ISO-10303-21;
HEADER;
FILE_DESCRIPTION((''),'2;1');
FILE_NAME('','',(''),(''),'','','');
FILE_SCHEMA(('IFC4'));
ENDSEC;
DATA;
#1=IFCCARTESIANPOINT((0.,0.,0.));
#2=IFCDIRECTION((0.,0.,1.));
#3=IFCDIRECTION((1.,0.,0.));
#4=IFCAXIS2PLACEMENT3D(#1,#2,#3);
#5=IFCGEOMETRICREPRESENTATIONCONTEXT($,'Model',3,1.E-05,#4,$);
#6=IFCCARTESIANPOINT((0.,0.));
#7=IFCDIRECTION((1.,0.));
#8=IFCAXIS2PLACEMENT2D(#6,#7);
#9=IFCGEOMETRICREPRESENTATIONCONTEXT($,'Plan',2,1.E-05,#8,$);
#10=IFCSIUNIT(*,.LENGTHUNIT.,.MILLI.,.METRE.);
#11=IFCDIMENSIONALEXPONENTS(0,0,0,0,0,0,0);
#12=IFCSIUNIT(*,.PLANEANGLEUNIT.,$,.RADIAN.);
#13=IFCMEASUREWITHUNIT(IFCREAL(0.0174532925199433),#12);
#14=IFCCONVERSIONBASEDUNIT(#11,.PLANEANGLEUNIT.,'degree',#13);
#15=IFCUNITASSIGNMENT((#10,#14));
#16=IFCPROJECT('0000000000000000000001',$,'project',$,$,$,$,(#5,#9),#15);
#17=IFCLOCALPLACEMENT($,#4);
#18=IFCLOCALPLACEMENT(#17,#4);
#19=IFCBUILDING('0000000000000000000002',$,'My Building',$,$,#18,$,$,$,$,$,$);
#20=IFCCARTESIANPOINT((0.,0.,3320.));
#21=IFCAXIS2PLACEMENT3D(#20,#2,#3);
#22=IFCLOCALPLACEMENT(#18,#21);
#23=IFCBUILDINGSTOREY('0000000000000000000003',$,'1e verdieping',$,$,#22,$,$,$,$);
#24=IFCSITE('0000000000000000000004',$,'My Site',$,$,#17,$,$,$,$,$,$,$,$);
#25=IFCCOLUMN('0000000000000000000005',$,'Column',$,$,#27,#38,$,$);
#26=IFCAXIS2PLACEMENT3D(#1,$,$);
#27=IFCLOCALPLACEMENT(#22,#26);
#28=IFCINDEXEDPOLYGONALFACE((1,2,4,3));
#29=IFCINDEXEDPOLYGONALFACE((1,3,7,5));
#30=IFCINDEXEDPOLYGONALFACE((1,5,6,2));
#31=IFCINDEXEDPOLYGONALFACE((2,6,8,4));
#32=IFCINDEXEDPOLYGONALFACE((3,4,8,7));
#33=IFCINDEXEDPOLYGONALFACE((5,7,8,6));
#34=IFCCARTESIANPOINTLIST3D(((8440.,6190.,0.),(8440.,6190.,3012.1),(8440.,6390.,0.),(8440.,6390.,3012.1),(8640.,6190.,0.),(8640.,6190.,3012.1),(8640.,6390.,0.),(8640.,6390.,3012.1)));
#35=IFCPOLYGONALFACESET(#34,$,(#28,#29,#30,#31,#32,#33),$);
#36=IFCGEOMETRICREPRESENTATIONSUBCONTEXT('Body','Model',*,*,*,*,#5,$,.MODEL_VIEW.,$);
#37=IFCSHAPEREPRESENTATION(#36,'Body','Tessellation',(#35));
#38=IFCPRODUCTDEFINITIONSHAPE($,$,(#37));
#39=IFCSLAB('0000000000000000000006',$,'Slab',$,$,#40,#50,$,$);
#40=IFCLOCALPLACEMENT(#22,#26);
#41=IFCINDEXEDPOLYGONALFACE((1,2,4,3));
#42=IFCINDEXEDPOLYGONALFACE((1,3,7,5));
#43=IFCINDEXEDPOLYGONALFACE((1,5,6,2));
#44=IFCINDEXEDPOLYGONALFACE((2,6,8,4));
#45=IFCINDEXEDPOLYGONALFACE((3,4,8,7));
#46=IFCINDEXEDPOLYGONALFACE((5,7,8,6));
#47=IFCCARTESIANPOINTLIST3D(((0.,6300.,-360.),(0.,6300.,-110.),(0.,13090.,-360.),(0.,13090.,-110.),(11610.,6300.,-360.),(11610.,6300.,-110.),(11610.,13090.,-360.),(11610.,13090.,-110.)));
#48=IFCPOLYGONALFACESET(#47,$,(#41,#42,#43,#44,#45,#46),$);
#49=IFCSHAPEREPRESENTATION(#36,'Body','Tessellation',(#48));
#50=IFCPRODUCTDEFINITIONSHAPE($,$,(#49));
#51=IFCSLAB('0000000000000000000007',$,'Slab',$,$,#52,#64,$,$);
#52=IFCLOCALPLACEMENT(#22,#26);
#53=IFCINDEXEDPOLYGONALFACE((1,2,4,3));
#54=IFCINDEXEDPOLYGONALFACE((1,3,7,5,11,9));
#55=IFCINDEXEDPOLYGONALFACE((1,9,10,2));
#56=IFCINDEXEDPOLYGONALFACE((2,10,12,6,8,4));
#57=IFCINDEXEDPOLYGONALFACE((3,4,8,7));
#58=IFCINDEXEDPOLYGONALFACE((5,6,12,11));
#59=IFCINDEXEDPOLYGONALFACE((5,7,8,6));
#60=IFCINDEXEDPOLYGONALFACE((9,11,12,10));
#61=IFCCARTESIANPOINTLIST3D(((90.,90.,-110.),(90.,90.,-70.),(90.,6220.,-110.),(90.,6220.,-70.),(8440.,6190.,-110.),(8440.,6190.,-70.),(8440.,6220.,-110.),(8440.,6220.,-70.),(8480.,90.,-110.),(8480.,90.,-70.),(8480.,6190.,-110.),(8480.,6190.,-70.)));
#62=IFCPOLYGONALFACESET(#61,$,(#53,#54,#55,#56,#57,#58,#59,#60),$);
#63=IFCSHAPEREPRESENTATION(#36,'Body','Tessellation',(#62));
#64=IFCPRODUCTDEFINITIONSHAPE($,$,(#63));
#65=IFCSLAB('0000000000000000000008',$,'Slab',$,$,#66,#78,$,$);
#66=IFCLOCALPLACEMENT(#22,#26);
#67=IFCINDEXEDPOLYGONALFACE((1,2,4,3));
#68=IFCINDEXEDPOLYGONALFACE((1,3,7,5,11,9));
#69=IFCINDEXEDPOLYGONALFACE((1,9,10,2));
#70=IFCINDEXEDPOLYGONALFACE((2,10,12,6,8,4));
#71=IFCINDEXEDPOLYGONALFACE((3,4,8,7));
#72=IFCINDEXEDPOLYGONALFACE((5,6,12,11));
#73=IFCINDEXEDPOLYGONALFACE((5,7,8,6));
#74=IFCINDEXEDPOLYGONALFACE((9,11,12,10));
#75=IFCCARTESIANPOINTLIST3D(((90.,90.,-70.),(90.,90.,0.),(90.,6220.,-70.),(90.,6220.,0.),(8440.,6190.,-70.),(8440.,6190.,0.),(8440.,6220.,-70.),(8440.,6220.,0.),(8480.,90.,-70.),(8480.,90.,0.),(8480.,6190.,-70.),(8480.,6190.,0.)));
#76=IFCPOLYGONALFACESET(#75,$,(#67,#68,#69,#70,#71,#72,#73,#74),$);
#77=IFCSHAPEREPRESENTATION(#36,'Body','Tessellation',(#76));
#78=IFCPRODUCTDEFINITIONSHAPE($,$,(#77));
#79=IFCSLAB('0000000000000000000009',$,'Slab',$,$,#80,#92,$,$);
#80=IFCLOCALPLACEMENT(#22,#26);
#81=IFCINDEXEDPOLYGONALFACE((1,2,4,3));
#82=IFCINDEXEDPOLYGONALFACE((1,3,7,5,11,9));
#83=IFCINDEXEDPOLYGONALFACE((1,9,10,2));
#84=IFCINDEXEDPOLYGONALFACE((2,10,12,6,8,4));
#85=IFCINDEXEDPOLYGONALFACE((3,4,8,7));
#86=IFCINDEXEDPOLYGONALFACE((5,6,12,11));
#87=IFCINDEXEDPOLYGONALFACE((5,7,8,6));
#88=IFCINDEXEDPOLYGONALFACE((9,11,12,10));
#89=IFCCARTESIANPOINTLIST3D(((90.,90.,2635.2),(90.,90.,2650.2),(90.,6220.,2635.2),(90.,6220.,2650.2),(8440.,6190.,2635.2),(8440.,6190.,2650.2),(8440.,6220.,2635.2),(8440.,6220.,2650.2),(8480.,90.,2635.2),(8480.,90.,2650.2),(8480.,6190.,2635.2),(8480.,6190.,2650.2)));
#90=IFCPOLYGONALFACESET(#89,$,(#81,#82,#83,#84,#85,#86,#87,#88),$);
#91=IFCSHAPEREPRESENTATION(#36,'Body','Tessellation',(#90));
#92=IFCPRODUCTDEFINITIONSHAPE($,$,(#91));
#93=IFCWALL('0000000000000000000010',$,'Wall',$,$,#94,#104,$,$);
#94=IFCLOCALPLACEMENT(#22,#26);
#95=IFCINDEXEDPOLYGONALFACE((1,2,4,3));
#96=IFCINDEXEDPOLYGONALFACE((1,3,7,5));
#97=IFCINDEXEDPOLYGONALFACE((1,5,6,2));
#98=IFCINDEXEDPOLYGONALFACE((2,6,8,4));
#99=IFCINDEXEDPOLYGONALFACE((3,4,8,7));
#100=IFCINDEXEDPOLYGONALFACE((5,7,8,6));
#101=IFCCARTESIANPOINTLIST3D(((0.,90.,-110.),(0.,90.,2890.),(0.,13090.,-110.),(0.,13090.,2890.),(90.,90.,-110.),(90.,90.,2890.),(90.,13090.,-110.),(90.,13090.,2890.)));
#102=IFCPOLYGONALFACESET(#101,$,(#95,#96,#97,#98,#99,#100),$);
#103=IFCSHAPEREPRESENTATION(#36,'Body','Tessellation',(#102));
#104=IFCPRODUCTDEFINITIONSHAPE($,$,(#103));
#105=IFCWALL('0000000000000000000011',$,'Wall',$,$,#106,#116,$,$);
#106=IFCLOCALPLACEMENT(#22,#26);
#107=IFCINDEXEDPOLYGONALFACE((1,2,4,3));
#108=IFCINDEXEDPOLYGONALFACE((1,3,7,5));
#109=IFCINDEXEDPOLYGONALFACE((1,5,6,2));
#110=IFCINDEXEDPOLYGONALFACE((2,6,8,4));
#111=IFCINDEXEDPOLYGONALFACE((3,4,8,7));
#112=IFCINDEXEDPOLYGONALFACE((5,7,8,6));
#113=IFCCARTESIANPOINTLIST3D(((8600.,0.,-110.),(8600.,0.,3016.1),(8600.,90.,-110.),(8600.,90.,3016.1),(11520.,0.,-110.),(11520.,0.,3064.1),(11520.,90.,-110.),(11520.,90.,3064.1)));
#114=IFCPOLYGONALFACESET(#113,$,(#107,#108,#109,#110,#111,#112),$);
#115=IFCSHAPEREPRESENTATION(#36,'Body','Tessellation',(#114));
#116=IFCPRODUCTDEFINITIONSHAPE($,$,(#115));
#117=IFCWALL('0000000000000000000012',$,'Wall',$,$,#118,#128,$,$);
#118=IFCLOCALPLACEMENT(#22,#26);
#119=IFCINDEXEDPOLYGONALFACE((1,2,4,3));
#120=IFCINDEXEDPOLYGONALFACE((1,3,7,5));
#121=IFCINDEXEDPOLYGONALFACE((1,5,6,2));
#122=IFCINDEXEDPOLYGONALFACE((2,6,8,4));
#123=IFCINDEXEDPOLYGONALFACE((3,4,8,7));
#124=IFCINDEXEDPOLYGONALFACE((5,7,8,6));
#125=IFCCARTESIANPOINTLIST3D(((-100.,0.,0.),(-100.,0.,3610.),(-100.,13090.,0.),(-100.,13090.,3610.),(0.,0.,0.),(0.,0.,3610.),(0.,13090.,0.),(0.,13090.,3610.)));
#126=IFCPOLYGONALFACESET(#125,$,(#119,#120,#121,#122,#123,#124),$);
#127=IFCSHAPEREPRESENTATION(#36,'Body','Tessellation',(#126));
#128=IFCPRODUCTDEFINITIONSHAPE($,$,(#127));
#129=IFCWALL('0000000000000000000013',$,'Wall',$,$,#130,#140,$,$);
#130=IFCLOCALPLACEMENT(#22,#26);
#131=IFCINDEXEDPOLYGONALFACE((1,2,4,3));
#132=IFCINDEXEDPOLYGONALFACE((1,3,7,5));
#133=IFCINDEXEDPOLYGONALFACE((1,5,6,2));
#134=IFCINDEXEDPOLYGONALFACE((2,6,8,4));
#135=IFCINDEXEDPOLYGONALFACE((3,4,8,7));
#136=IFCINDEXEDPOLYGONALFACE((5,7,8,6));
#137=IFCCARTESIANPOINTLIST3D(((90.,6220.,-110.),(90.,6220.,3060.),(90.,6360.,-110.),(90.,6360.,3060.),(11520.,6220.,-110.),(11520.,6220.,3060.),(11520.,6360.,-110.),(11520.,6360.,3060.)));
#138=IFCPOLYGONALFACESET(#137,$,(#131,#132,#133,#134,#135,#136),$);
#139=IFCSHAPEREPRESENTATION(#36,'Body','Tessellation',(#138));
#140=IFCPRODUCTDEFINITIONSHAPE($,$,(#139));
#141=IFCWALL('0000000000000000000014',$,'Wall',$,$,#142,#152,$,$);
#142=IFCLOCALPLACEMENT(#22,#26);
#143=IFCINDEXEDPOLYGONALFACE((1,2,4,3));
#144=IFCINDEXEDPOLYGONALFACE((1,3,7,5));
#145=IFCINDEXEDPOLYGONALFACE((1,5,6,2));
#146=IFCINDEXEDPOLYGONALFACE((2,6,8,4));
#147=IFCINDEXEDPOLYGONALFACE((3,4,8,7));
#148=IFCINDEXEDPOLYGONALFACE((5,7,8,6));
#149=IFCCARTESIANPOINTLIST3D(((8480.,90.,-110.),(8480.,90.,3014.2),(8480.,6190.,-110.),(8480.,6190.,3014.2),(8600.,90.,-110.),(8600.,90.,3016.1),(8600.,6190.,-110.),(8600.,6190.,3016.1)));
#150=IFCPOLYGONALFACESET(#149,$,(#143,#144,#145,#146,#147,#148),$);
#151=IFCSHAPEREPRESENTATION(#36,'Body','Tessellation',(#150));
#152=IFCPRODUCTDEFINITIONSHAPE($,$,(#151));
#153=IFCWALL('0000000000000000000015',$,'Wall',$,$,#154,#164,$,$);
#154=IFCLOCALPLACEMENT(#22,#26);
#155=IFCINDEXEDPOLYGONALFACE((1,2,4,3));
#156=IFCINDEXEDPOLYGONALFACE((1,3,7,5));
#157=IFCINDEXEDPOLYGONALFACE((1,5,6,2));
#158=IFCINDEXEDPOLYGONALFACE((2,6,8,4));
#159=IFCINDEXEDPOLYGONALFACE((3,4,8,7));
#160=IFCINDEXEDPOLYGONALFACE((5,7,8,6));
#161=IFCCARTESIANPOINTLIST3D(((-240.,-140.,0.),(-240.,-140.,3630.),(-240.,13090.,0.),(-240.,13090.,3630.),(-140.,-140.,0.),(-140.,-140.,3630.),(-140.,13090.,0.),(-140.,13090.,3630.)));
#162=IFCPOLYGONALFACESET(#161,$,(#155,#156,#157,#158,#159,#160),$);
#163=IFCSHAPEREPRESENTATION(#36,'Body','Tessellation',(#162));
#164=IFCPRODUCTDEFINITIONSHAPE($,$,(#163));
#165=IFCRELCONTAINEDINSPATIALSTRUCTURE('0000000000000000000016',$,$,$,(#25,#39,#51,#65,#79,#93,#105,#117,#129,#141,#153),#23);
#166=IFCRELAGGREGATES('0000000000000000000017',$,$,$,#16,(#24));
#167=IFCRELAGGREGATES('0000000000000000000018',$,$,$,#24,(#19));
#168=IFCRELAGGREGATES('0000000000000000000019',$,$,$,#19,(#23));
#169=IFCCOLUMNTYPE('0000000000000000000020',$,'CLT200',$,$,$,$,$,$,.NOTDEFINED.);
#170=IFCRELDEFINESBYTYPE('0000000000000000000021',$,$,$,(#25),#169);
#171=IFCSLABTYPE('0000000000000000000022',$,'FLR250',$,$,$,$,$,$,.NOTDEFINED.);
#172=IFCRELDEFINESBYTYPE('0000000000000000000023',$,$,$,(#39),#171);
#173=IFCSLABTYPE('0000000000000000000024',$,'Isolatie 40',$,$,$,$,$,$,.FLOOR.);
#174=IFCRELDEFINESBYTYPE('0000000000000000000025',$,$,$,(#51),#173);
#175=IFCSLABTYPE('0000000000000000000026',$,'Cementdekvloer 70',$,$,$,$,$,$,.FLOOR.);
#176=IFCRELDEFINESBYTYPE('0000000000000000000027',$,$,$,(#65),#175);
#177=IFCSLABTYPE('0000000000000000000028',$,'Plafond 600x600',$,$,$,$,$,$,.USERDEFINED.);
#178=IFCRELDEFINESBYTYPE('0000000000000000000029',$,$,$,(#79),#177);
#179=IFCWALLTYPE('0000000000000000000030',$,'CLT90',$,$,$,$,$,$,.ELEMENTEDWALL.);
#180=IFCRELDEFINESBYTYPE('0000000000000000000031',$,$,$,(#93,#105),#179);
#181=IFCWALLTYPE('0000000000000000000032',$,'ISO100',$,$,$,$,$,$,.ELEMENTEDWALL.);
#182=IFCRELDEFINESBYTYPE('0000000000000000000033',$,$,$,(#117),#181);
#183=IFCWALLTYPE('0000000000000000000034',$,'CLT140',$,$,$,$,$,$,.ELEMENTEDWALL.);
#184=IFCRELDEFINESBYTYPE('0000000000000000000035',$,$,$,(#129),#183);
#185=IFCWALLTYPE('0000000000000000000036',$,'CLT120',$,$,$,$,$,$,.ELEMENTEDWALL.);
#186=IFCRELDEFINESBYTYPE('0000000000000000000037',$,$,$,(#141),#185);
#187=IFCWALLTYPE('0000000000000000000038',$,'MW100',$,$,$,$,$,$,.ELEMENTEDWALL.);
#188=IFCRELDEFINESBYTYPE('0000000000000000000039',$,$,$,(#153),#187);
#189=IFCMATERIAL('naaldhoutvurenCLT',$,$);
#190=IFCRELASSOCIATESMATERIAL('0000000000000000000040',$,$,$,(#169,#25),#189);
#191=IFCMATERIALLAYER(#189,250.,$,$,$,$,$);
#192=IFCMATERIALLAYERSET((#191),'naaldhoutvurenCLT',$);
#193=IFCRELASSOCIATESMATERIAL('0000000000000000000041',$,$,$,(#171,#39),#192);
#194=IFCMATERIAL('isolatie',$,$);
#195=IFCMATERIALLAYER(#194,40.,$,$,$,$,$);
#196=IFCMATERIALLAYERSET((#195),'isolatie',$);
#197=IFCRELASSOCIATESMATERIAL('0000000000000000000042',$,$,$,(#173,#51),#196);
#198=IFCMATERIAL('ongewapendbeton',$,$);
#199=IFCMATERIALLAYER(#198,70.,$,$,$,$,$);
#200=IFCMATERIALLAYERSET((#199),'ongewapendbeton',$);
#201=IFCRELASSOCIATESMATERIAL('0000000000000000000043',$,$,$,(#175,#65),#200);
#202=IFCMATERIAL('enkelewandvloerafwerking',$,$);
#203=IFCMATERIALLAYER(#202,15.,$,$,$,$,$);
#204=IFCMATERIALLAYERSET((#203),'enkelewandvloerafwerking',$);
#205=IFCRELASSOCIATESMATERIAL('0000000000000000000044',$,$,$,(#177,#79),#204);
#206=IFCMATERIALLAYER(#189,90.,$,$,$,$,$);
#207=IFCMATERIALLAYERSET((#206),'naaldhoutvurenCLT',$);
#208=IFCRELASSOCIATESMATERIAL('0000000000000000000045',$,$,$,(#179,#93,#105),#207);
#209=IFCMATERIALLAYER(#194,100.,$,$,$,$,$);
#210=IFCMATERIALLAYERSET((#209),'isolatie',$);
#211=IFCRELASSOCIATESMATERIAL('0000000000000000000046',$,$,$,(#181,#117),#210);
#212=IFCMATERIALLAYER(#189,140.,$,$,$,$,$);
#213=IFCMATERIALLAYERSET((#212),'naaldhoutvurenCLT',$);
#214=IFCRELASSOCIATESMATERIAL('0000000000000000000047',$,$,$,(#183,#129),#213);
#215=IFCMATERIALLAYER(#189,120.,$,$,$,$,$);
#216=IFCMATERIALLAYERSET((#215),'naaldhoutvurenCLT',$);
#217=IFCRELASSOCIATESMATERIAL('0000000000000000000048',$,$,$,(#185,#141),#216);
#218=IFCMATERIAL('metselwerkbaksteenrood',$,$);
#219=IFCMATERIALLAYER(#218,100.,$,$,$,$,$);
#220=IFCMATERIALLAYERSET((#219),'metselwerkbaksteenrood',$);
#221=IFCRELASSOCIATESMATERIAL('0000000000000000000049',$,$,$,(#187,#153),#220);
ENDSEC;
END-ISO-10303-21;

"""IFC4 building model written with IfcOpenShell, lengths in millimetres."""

from ifc_helpers import new_model, entity, si_unit, converted_unit, frame, origin_with_axes, origin_2d_with_axis, place, context, subcontext, project, spatial, line, indexed_curve, rectangle, outline, extrude, clip, halfspace, material, layer, layer_set, layer_usage, material_profile, profile_set, profile_usage, type_object, element, save


model = new_model("IFC4")

# Units and contexts
model_context = context("Model", 3, precision=1e-05, world=origin_with_axes())
plan_context = context("Plan", 2, precision=1e-05, world=origin_2d_with_axis())
body_context = subcontext(model_context, "Body", "Model", "MODEL_VIEW")
ifc_project = project(units=[si_unit("LENGTHUNIT", "METRE", prefix="MILLI"), converted_unit("PLANEANGLEUNIT", "degree", entity("IfcReal", 0.0174532925199433), si_unit("PLANEANGLEUNIT", "RADIAN"), dimensions=[0, 0, 0, 0, 0, 0, 0])], contexts=[model_context, plan_context])

# Site, building, storey
site_placement = place(None, origin_with_axes())
site = spatial("IfcSite", under=ifc_project, at=site_placement, Name="My Site")
building_placement = place(site_placement, origin_with_axes())
building = spatial("IfcBuilding", under=site, at=building_placement, Name="My Building")
storey_placement = place(building_placement, frame((0.0, 0.0, 3320.0), z_axis=(0.0, 0.0, 1.0), x_axis=(1.0, 0.0, 0.0)))
storey = spatial("IfcBuildingStorey", under=building, at=storey_placement, Name="1e verdieping")

# Column
ifc_material_1 = material(Name="naaldhoutvurenCLT")
ifc_material_profile = material_profile(ifc_material_1, rectangle(XDim=200.0, YDim=200.0))
ifc_profile_set = profile_set([ifc_material_profile], Name="naaldhoutvurenCLT")
ifc_profile_usage = profile_usage(ifc_profile_set, cardinal=5)
column_type = type_object("IfcColumnType", Name="CLT200", PredefinedType="NOTDEFINED", material=ifc_profile_set)
column_placement = place(storey_placement, frame((8540.0, 6290.0, 0.0), z_axis=(0.0, 0.0, 1.0), x_axis=(1.0, 0.0, 0.0)))
element("IfcColumn", 1, at=column_placement, inside=storey, type_object=column_type, material=ifc_profile_usage, Name="Column", context=body_context, shape_type="SweptSolid", body=[
    extrude(rectangle(XDim=200.0, YDim=200.0), origin_with_axes(), (0.0, 0.0, 1.0), 3012.1),
])

# Slabs
ifc_layer_1 = layer(ifc_material_1, 250.0)
ifc_layer_set_1 = layer_set([ifc_layer_1], Name="naaldhoutvurenCLT")
slab_type_1 = type_object("IfcSlabType", Name="FLR250", PredefinedType="NOTDEFINED", material=ifc_layer_set_1)
ifc_layer_usage_1 = layer_usage(ifc_layer_set_1, "AXIS3", "POSITIVE", 0.0)
slab_1_placement = place(storey_placement, frame((0.0, 6300.0, -360.0), z_axis=(0.0, 0.0, 1.0), x_axis=(1.0, 0.0, 0.0)))
element("IfcSlab", 2, at=slab_1_placement, inside=storey, type_object=slab_type_1, material=ifc_layer_usage_1, Name="Slab", context=body_context, shape_type="SweptSolid", body=[
    extrude(outline(indexed_curve([(0.0, 6790.0), (0.0, 0.0), (11610.0, 0.0), (11610.0, 6790.0)], segments=[line(3, 2), line(2, 1), line(1, 4), line(4, 3)], self_intersect=False)), None, (0.0, 0.0, 1.0), 250.0),
])
ifc_material_2 = material(Name="isolatie")
ifc_layer_2 = layer(ifc_material_2, 40.0)
ifc_layer_set_2 = layer_set([ifc_layer_2], Name="isolatie")
ifc_layer_usage_2 = layer_usage(ifc_layer_set_2, "AXIS3", "POSITIVE", 0.0)
slab_type_2 = type_object("IfcSlabType", Name="Isolatie 40", PredefinedType="FLOOR", material=ifc_layer_set_2)
slab_2_placement = place(storey_placement, frame((90.0, 90.0, -110.0), z_axis=(0.0, 0.0, 1.0), x_axis=(1.0, 0.0, 0.0)))
element("IfcSlab", 3, at=slab_2_placement, inside=storey, type_object=slab_type_2, material=ifc_layer_usage_2, Name="Slab", context=body_context, shape_type="SweptSolid", body=[
    extrude(outline(indexed_curve([(0.0, 0.0), (8390.0, 0.0), (8350.0, 6130.0), (0.0, 6130.0), (8350.0, 6100.0), (8390.0, 6100.0)], segments=[line(2, 1), line(1, 4), line(4, 3), line(3, 5), line(5, 6), line(6, 2)], self_intersect=False)), None, (0.0, 0.0, 1.0), 40.0),
])
ifc_material_3 = material(Name="ongewapendbeton")
ifc_layer_3 = layer(ifc_material_3, 70.0)
ifc_layer_set_3 = layer_set([ifc_layer_3], Name="ongewapendbeton")
ifc_layer_usage_3 = layer_usage(ifc_layer_set_3, "AXIS3", "POSITIVE", 0.0)
slab_type_3 = type_object("IfcSlabType", Name="Cementdekvloer 70", PredefinedType="FLOOR", material=ifc_layer_set_3)
slab_3_placement = place(storey_placement, frame((90.0, 90.0, -70.0), z_axis=(0.0, 0.0, 1.0), x_axis=(1.0, 0.0, 0.0)))
element("IfcSlab", 4, at=slab_3_placement, inside=storey, type_object=slab_type_3, material=ifc_layer_usage_3, Name="Slab", context=body_context, shape_type="SweptSolid", body=[
    extrude(outline(indexed_curve([(0.0, 0.0), (8390.0, 0.0), (8350.0, 6130.0), (0.0, 6130.0), (8350.0, 6100.0), (8390.0, 6100.0)], segments=[line(2, 1), line(1, 4), line(4, 3), line(3, 5), line(5, 6), line(6, 2)], self_intersect=False)), None, (0.0, 0.0, 1.0), 70.0),
])
ifc_material_4 = material(Name="enkelewandvloerafwerking")
ifc_layer_4 = layer(ifc_material_4, 15.0)
ifc_layer_set_4 = layer_set([ifc_layer_4], Name="enkelewandvloerafwerking")
ifc_layer_usage_4 = layer_usage(ifc_layer_set_4, "AXIS3", "POSITIVE", 0.0)
slab_type_4 = type_object("IfcSlabType", Name="Plafond 600x600", PredefinedType="USERDEFINED", material=ifc_layer_set_4)
slab_4_placement = place(storey_placement, frame((90.0, 90.0, 2635.2), z_axis=(0.0, 0.0, 1.0), x_axis=(1.0, 0.0, 0.0)))
element("IfcSlab", 5, at=slab_4_placement, inside=storey, type_object=slab_type_4, material=ifc_layer_usage_4, Name="Slab", context=body_context, shape_type="SweptSolid", body=[
    extrude(outline(indexed_curve([(0.0, 0.0), (8390.0, 0.0), (8350.0, 6130.0), (0.0, 6130.0), (8350.0, 6100.0), (8390.0, 6100.0)], segments=[line(3, 5), line(5, 6), line(6, 2), line(2, 1), line(1, 4), line(4, 3)], self_intersect=False)), None, (0.0, 0.0, 1.0), 15.0),
])

# Walls
ifc_layer_5 = layer(ifc_material_1, 90.0)
ifc_layer_set_5 = layer_set([ifc_layer_5], Name="naaldhoutvurenCLT")
ifc_layer_usage_5 = layer_usage(ifc_layer_set_5, "AXIS2", "POSITIVE", 0.0)
wall_type_1 = type_object("IfcWallType", Name="CLT90", PredefinedType="ELEMENTEDWALL", material=ifc_layer_set_5)
wall_1_placement = place(storey_placement, frame((90.0, 90.0, -110.0), z_axis=(0.0, 0.0, 1.0), x_axis=(0.0, 1.0, 0.0)))
element("IfcWall", 6, at=wall_1_placement, inside=storey, type_object=wall_type_1, material=ifc_layer_usage_5, Name="Wall", context=body_context, shape_type="SweptSolid", body=[
    extrude(outline(indexed_curve([(0.0, 0.0), (0.0, 90.0), (13000.0, 90.0), (13000.0, 0.0), (0.0, 0.0)], self_intersect=False)), origin_with_axes(), (0.0, 0.0, 1.0), 3000.0),
])
ifc_layer_usage_6 = layer_usage(ifc_layer_set_5, "AXIS2", "POSITIVE", 0.0)
wall_2_placement = place(storey_placement, frame((8600.0, 0.0, -110.0), z_axis=(0.0, 0.0, 1.0), x_axis=(1.0, 0.0, 0.0)))
element("IfcWall", 7, at=wall_2_placement, inside=storey, type_object=wall_type_1, material=ifc_layer_usage_6, Name="Wall", context=body_context, shape_type="Clipping", body=[
    clip(extrude(outline(indexed_curve([(0.0, 0.0), (0.0, 90.0), (2920.0, 90.0), (2920.0, 0.0), (0.0, 0.0)], self_intersect=False)), origin_with_axes(), (0.0, 0.0, 1.0), 6384.1), halfspace(frame((2920.0, 0.0, 3174.1), z_axis=(-0.016405, 0.0, 0.999865), x_axis=(0.0, 1.0, 0.0)), False)),
])
ifc_layer_6 = layer(ifc_material_2, 100.0)
ifc_layer_set_6 = layer_set([ifc_layer_6], Name="isolatie")
ifc_layer_usage_7 = layer_usage(ifc_layer_set_6, "AXIS2", "POSITIVE", 0.0)
wall_type_2 = type_object("IfcWallType", Name="ISO100", PredefinedType="ELEMENTEDWALL", material=ifc_layer_set_6)
wall_3_placement = place(storey_placement, frame((0.0, 0.0, 0.0), z_axis=(0.0, 0.0, 1.0), x_axis=(0.0, 1.0, 0.0)))
element("IfcWall", 8, at=wall_3_placement, inside=storey, type_object=wall_type_2, material=ifc_layer_usage_7, Name="Wall", context=body_context, shape_type="SweptSolid", body=[
    extrude(outline(indexed_curve([(0.0, 0.0), (0.0, 100.0), (13090.0, 100.0), (13090.0, 0.0), (0.0, 0.0)], self_intersect=False)), origin_with_axes(), (0.0, 0.0, 1.0), 3610.0),
])
ifc_layer_7 = layer(ifc_material_1, 140.0)
ifc_layer_set_7 = layer_set([ifc_layer_7], Name="naaldhoutvurenCLT")
ifc_layer_usage_8 = layer_usage(ifc_layer_set_7, "AXIS2", "POSITIVE", 0.0)
wall_type_3 = type_object("IfcWallType", Name="CLT140", PredefinedType="ELEMENTEDWALL", material=ifc_layer_set_7)
wall_4_placement = place(storey_placement, frame((90.0, 6220.0, -110.0), z_axis=(0.0, 0.0, 1.0), x_axis=(1.0, -0.000001, 0.0)))
element("IfcWall", 9, at=wall_4_placement, inside=storey, type_object=wall_type_3, material=ifc_layer_usage_8, Name="Wall", context=body_context, shape_type="SweptSolid", body=[
    extrude(outline(indexed_curve([(0.0, 0.0), (0.0, 140.0), (11430.0, 140.0), (11430.0, 0.0), (0.0, 0.0)], self_intersect=False)), origin_with_axes(), (0.0, 0.0, 1.0), 3170.0),
])
ifc_layer_8 = layer(ifc_material_1, 120.0)
ifc_layer_set_8 = layer_set([ifc_layer_8], Name="naaldhoutvurenCLT")
ifc_layer_usage_9 = layer_usage(ifc_layer_set_8, "AXIS2", "POSITIVE", 0.0)
wall_type_4 = type_object("IfcWallType", Name="CLT120", PredefinedType="ELEMENTEDWALL", material=ifc_layer_set_8)
wall_5_placement = place(storey_placement, frame((8600.0, 90.0, -110.0), z_axis=(0.0, 0.0, 1.0), x_axis=(0.0, 1.0, 0.0)))
element("IfcWall", 10, at=wall_5_placement, inside=storey, type_object=wall_type_4, material=ifc_layer_usage_9, Name="Wall", context=body_context, shape_type="Clipping", body=[
    clip(extrude(outline(indexed_curve([(0.0, 0.0), (0.0, 120.0), (6100.0, 120.0), (6100.0, 0.0), (0.0, 0.0)], self_intersect=False)), origin_with_axes(), (0.0, 0.0, 1.0), 6336.1), halfspace(frame((0.0, 0.0, 3126.1), z_axis=(0.0, 0.016405, 0.999865), x_axis=(1.0, 0.0, 0.0)), False)),
])

# Shared definitions
ifc_material_5 = material(Name="metselwerkbaksteenrood")
ifc_layer_9 = layer(ifc_material_5, 100.0)
ifc_layer_set_9 = layer_set([ifc_layer_9], Name="metselwerkbaksteenrood")
wall_type_5 = type_object("IfcWallType", Name="MW100", PredefinedType="ELEMENTEDWALL", material=ifc_layer_set_9)

# Wall
ifc_layer_usage_10 = layer_usage(ifc_layer_set_9, "AXIS2", "POSITIVE", 0.0)
wall_6_placement = place(storey_placement, frame((-240.0, 13090.0, 0.0), z_axis=(0.0, 0.0, 1.0), x_axis=(0.0, -1.0, 0.0)))
element("IfcWall", 11, at=wall_6_placement, inside=storey, type_object=wall_type_5, material=ifc_layer_usage_10, Name="Wall", context=body_context, shape_type="SweptSolid", body=[
    extrude(outline(indexed_curve([(0.0, 0.0), (0.0, 100.0), (13230.0, 100.0), (13230.0, 0.0), (0.0, 0.0)], self_intersect=False)), origin_with_axes(), (0.0, 0.0, 1.0), 3630.0),
])

save(model, "model.ifc")
